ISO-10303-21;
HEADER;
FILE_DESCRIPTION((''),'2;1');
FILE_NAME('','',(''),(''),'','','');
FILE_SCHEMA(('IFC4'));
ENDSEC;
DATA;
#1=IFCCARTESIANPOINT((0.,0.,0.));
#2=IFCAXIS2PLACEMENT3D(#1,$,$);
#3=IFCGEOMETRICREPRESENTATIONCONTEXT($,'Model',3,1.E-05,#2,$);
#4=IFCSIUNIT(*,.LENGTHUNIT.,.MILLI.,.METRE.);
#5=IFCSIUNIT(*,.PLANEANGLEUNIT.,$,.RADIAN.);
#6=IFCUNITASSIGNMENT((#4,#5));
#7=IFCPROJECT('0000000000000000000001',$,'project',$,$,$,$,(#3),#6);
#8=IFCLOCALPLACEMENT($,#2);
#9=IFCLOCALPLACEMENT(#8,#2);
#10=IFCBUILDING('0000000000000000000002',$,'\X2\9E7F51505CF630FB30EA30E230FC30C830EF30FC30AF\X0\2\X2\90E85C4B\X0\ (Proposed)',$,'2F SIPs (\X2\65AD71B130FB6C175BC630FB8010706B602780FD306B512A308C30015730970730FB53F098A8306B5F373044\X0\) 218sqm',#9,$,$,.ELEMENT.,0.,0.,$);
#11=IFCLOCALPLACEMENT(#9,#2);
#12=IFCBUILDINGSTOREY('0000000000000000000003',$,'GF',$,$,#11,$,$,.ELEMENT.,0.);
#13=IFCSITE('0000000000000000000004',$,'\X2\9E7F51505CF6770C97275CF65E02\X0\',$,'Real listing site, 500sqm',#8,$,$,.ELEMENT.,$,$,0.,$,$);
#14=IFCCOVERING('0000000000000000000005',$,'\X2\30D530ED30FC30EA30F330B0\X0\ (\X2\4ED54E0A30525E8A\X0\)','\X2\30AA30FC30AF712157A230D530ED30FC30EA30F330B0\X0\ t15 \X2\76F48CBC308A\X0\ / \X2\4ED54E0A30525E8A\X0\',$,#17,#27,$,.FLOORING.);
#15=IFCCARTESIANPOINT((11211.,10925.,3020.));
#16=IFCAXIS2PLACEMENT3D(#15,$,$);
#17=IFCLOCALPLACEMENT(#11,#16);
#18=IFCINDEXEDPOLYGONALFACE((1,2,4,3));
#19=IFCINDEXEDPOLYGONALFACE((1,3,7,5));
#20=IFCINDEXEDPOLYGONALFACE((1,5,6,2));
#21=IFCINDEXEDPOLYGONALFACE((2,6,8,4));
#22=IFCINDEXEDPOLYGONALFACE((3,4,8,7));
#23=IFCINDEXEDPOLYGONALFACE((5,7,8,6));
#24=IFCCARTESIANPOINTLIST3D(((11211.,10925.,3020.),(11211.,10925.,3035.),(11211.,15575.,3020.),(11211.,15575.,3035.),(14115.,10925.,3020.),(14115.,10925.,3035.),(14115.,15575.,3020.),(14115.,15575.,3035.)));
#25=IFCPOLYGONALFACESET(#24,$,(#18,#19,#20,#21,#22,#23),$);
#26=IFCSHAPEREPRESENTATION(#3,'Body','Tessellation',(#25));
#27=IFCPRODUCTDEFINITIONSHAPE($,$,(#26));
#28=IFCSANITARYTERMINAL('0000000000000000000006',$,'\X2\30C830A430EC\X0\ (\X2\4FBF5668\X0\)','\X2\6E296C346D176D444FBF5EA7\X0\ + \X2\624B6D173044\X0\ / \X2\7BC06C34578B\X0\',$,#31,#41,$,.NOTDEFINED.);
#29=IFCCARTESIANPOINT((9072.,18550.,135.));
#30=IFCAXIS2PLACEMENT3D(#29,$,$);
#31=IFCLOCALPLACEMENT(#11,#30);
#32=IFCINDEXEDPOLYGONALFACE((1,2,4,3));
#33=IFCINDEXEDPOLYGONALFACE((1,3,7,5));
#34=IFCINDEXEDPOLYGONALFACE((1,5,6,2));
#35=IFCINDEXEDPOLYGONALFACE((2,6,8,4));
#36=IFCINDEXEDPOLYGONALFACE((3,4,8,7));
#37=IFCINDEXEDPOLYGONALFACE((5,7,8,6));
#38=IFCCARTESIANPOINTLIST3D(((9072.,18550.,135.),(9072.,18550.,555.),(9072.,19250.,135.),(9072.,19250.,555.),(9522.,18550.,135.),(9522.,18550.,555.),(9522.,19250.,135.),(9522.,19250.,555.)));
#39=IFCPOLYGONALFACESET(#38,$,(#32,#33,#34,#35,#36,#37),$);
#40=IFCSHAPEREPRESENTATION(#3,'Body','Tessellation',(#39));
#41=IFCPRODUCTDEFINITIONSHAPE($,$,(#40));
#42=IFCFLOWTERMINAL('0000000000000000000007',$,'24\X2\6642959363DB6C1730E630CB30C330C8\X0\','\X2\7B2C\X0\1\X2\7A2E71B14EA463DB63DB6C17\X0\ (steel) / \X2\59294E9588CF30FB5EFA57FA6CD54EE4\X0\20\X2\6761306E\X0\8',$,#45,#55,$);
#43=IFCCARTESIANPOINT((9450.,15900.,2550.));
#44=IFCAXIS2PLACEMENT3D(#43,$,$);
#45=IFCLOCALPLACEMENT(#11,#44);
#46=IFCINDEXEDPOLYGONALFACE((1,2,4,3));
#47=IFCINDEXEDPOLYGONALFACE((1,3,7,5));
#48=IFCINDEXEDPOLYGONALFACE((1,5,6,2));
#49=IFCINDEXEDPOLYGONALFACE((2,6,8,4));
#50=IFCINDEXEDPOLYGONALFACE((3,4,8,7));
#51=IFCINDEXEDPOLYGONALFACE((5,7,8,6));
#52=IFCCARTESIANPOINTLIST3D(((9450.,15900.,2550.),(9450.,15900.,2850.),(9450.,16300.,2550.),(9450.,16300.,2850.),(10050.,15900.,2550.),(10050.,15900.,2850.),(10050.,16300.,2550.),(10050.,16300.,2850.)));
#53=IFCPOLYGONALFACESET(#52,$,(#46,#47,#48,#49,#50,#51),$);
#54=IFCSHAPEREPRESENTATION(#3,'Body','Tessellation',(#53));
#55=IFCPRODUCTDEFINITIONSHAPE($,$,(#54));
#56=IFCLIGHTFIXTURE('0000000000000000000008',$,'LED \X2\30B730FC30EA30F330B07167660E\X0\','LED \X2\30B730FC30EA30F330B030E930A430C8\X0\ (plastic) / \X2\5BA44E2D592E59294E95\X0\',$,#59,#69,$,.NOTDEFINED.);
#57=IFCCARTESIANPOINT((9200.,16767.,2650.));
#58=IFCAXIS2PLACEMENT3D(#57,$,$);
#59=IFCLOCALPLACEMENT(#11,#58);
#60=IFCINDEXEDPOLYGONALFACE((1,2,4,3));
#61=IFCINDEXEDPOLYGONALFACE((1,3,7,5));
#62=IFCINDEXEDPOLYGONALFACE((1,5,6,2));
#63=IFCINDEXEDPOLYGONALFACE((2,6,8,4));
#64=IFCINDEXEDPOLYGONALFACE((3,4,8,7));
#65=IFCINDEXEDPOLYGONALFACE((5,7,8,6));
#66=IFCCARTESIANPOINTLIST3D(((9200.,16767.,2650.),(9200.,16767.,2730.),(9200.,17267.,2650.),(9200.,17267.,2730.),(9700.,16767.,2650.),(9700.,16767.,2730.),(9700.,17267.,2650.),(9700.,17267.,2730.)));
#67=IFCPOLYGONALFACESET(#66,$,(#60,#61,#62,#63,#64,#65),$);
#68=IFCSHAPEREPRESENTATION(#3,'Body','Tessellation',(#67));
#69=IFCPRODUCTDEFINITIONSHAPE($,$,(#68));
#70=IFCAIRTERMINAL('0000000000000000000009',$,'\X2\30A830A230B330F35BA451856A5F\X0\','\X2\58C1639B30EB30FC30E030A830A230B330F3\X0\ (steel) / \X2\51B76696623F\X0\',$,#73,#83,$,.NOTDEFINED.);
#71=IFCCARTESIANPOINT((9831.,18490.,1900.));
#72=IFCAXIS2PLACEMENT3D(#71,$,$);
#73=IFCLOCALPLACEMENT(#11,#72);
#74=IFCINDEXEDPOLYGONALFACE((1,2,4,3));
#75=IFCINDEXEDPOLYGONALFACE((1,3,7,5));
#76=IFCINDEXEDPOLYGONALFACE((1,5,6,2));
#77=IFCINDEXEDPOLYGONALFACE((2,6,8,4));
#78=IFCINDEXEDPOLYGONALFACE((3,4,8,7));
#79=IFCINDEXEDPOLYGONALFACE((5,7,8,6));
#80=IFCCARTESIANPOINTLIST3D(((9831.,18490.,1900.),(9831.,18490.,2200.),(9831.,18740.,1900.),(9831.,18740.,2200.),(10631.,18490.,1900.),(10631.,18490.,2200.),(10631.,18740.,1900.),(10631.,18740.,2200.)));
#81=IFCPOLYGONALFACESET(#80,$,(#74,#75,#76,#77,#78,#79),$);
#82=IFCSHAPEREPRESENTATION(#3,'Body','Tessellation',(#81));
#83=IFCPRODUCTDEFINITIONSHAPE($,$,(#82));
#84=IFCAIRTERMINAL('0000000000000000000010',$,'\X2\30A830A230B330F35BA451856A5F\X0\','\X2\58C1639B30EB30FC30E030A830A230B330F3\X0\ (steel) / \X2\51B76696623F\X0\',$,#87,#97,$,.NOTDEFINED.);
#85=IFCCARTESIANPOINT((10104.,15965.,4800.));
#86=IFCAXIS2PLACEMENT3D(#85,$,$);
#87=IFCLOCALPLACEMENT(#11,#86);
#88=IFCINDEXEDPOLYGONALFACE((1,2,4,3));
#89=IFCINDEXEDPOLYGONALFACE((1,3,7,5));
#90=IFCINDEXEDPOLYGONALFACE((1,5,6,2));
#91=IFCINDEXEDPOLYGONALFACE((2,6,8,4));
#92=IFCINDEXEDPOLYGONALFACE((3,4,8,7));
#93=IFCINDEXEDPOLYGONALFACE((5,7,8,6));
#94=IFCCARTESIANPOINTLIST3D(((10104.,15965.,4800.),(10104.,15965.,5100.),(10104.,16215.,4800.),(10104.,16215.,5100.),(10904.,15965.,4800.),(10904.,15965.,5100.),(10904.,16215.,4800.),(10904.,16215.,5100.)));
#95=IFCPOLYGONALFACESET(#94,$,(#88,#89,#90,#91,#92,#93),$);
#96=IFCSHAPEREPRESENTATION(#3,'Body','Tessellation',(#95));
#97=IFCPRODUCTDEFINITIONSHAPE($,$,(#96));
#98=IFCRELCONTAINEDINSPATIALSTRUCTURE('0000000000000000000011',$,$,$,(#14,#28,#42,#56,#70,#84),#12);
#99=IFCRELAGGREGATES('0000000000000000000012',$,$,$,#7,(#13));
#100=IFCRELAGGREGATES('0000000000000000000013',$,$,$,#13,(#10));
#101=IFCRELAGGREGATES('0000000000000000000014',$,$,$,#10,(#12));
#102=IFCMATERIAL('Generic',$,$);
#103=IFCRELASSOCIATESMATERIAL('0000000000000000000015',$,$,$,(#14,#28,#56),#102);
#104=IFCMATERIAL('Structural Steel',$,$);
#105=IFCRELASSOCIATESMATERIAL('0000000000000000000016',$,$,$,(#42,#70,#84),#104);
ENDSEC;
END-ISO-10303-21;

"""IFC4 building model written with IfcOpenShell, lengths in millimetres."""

from ifc_helpers import new_model, si_unit, frame, frame_2d, origin, place, context, project, spatial, rectangle, extrude, material, element, save


model = new_model("IFC4")

# Units and contexts
model_context = context("Model", 3, precision=1e-05, world=origin())
ifc_project = project(units=[si_unit("LENGTHUNIT", "METRE", prefix="MILLI"), si_unit("PLANEANGLEUNIT", "RADIAN")], contexts=[model_context])

# Site, building, storey
site_placement = place(None, origin())
site = spatial("IfcSite", under=ifc_project, at=site_placement, Name="鹿児島県霧島市", ObjectType="Real listing site, 500sqm", CompositionType="ELEMENT", RefElevation=0.0)
building_placement = place(site_placement, origin())
building = spatial("IfcBuilding", under=site, at=building_placement, Name="鹿児島・リモートワーク2部屋 (Proposed)", ObjectType="2F SIPs (断熱・気密・耐火性能に優れ、地震・台風に強い) 218sqm", CompositionType="ELEMENT", ElevationOfRefHeight=0.0, ElevationOfTerrain=0.0)
storey_placement = place(building_placement, origin())
storey = spatial("IfcBuildingStorey", under=building, at=storey_placement, Name="GF", CompositionType="ELEMENT", Elevation=0.0)

# Covering
ifc_material_1 = material(Name="Generic")
covering_1_placement = place(storey_placement, frame((11211.0, 10925.0, 3020.0)))
element("IfcCovering", 1, at=covering_1_placement, inside=storey, material=ifc_material_1, Name="フローリング (仕上げ床)", Description="オーク無垢フローリング t15 直貼り / 仕上げ床", PredefinedType="FLOORING", context=model_context, shape_type="SweptSolid", body=[
    extrude(rectangle(XDim=2904.0, YDim=4650.0, at=frame_2d((1452.0, 2325.0))), frame((11211.0, 10925.0, 3020.0)), (0.0, 0.0, 1.0), 15.0),
])

# Sanitary terminal
sanitary_terminal_placement = place(storey_placement, frame((9072.0, 18550.0, 135.0)))
element("IfcSanitaryTerminal", 2, at=sanitary_terminal_placement, inside=storey, material=ifc_material_1, Name="トイレ (便器)", Description="温水洗浄便座 + 手洗い / 節水型", PredefinedType="NOTDEFINED", context=model_context, shape_type="SweptSolid", body=[
    extrude(rectangle(XDim=450.0, YDim=700.0, at=frame_2d((225.0, 350.0))), frame((9072.0, 18550.0, 135.0)), (0.0, 0.0, 1.0), 420.0),
])

# Flow terminal
ifc_material_2 = material(Name="Structural Steel")
flow_terminal_placement = place(storey_placement, frame((9450.0, 15900.0, 2550.0)))
element("IfcFlowTerminal", 3, at=flow_terminal_placement, inside=storey, material=ifc_material_2, Name="24時間換気ユニット", Description="第1種熱交換換気 (steel) / 天井裏・建基法令20条の8", context=model_context, shape_type="SweptSolid", body=[
    extrude(rectangle(XDim=600.0, YDim=400.0, at=frame_2d((300.0, 200.0))), frame((9450.0, 15900.0, 2550.0)), (0.0, 0.0, 1.0), 300.0),
])

# Light fixture
light_fixture_placement = place(storey_placement, frame((9200.0, 16767.0, 2650.0)))
element("IfcLightFixture", 4, at=light_fixture_placement, inside=storey, material=ifc_material_1, Name="LED シーリング照明", Description="LED シーリングライト (plastic) / 室中央天井", PredefinedType="NOTDEFINED", context=model_context, shape_type="SweptSolid", body=[
    extrude(rectangle(XDim=500.0, YDim=500.0, at=frame_2d((250.0, 250.0))), frame((9200.0, 16767.0, 2650.0)), (0.0, 0.0, 1.0), 80.0),
])

# Air terminals
air_terminal_1_placement = place(storey_placement, frame((9831.0, 18490.0, 1900.0)))
element("IfcAirTerminal", 5, at=air_terminal_1_placement, inside=storey, material=ifc_material_2, Name="エアコン室内機", Description="壁掛ルームエアコン (steel) / 冷暖房", PredefinedType="NOTDEFINED", context=model_context, shape_type="SweptSolid", body=[
    extrude(rectangle(XDim=800.0, YDim=250.0, at=frame_2d((400.0, 125.0))), frame((9831.0, 18490.0, 1900.0)), (0.0, 0.0, 1.0), 300.0),
])
air_terminal_2_placement = place(storey_placement, frame((10104.0, 15965.0, 4800.0)))
element("IfcAirTerminal", 6, at=air_terminal_2_placement, inside=storey, material=ifc_material_2, Name="エアコン室内機", Description="壁掛ルームエアコン (steel) / 冷暖房", PredefinedType="NOTDEFINED", context=model_context, shape_type="SweptSolid", body=[
    extrude(rectangle(XDim=800.0, YDim=250.0, at=frame_2d((400.0, 125.0))), frame((10104.0, 15965.0, 4800.0)), (0.0, 0.0, 1.0), 300.0),
])

save(model, "model.ifc")
